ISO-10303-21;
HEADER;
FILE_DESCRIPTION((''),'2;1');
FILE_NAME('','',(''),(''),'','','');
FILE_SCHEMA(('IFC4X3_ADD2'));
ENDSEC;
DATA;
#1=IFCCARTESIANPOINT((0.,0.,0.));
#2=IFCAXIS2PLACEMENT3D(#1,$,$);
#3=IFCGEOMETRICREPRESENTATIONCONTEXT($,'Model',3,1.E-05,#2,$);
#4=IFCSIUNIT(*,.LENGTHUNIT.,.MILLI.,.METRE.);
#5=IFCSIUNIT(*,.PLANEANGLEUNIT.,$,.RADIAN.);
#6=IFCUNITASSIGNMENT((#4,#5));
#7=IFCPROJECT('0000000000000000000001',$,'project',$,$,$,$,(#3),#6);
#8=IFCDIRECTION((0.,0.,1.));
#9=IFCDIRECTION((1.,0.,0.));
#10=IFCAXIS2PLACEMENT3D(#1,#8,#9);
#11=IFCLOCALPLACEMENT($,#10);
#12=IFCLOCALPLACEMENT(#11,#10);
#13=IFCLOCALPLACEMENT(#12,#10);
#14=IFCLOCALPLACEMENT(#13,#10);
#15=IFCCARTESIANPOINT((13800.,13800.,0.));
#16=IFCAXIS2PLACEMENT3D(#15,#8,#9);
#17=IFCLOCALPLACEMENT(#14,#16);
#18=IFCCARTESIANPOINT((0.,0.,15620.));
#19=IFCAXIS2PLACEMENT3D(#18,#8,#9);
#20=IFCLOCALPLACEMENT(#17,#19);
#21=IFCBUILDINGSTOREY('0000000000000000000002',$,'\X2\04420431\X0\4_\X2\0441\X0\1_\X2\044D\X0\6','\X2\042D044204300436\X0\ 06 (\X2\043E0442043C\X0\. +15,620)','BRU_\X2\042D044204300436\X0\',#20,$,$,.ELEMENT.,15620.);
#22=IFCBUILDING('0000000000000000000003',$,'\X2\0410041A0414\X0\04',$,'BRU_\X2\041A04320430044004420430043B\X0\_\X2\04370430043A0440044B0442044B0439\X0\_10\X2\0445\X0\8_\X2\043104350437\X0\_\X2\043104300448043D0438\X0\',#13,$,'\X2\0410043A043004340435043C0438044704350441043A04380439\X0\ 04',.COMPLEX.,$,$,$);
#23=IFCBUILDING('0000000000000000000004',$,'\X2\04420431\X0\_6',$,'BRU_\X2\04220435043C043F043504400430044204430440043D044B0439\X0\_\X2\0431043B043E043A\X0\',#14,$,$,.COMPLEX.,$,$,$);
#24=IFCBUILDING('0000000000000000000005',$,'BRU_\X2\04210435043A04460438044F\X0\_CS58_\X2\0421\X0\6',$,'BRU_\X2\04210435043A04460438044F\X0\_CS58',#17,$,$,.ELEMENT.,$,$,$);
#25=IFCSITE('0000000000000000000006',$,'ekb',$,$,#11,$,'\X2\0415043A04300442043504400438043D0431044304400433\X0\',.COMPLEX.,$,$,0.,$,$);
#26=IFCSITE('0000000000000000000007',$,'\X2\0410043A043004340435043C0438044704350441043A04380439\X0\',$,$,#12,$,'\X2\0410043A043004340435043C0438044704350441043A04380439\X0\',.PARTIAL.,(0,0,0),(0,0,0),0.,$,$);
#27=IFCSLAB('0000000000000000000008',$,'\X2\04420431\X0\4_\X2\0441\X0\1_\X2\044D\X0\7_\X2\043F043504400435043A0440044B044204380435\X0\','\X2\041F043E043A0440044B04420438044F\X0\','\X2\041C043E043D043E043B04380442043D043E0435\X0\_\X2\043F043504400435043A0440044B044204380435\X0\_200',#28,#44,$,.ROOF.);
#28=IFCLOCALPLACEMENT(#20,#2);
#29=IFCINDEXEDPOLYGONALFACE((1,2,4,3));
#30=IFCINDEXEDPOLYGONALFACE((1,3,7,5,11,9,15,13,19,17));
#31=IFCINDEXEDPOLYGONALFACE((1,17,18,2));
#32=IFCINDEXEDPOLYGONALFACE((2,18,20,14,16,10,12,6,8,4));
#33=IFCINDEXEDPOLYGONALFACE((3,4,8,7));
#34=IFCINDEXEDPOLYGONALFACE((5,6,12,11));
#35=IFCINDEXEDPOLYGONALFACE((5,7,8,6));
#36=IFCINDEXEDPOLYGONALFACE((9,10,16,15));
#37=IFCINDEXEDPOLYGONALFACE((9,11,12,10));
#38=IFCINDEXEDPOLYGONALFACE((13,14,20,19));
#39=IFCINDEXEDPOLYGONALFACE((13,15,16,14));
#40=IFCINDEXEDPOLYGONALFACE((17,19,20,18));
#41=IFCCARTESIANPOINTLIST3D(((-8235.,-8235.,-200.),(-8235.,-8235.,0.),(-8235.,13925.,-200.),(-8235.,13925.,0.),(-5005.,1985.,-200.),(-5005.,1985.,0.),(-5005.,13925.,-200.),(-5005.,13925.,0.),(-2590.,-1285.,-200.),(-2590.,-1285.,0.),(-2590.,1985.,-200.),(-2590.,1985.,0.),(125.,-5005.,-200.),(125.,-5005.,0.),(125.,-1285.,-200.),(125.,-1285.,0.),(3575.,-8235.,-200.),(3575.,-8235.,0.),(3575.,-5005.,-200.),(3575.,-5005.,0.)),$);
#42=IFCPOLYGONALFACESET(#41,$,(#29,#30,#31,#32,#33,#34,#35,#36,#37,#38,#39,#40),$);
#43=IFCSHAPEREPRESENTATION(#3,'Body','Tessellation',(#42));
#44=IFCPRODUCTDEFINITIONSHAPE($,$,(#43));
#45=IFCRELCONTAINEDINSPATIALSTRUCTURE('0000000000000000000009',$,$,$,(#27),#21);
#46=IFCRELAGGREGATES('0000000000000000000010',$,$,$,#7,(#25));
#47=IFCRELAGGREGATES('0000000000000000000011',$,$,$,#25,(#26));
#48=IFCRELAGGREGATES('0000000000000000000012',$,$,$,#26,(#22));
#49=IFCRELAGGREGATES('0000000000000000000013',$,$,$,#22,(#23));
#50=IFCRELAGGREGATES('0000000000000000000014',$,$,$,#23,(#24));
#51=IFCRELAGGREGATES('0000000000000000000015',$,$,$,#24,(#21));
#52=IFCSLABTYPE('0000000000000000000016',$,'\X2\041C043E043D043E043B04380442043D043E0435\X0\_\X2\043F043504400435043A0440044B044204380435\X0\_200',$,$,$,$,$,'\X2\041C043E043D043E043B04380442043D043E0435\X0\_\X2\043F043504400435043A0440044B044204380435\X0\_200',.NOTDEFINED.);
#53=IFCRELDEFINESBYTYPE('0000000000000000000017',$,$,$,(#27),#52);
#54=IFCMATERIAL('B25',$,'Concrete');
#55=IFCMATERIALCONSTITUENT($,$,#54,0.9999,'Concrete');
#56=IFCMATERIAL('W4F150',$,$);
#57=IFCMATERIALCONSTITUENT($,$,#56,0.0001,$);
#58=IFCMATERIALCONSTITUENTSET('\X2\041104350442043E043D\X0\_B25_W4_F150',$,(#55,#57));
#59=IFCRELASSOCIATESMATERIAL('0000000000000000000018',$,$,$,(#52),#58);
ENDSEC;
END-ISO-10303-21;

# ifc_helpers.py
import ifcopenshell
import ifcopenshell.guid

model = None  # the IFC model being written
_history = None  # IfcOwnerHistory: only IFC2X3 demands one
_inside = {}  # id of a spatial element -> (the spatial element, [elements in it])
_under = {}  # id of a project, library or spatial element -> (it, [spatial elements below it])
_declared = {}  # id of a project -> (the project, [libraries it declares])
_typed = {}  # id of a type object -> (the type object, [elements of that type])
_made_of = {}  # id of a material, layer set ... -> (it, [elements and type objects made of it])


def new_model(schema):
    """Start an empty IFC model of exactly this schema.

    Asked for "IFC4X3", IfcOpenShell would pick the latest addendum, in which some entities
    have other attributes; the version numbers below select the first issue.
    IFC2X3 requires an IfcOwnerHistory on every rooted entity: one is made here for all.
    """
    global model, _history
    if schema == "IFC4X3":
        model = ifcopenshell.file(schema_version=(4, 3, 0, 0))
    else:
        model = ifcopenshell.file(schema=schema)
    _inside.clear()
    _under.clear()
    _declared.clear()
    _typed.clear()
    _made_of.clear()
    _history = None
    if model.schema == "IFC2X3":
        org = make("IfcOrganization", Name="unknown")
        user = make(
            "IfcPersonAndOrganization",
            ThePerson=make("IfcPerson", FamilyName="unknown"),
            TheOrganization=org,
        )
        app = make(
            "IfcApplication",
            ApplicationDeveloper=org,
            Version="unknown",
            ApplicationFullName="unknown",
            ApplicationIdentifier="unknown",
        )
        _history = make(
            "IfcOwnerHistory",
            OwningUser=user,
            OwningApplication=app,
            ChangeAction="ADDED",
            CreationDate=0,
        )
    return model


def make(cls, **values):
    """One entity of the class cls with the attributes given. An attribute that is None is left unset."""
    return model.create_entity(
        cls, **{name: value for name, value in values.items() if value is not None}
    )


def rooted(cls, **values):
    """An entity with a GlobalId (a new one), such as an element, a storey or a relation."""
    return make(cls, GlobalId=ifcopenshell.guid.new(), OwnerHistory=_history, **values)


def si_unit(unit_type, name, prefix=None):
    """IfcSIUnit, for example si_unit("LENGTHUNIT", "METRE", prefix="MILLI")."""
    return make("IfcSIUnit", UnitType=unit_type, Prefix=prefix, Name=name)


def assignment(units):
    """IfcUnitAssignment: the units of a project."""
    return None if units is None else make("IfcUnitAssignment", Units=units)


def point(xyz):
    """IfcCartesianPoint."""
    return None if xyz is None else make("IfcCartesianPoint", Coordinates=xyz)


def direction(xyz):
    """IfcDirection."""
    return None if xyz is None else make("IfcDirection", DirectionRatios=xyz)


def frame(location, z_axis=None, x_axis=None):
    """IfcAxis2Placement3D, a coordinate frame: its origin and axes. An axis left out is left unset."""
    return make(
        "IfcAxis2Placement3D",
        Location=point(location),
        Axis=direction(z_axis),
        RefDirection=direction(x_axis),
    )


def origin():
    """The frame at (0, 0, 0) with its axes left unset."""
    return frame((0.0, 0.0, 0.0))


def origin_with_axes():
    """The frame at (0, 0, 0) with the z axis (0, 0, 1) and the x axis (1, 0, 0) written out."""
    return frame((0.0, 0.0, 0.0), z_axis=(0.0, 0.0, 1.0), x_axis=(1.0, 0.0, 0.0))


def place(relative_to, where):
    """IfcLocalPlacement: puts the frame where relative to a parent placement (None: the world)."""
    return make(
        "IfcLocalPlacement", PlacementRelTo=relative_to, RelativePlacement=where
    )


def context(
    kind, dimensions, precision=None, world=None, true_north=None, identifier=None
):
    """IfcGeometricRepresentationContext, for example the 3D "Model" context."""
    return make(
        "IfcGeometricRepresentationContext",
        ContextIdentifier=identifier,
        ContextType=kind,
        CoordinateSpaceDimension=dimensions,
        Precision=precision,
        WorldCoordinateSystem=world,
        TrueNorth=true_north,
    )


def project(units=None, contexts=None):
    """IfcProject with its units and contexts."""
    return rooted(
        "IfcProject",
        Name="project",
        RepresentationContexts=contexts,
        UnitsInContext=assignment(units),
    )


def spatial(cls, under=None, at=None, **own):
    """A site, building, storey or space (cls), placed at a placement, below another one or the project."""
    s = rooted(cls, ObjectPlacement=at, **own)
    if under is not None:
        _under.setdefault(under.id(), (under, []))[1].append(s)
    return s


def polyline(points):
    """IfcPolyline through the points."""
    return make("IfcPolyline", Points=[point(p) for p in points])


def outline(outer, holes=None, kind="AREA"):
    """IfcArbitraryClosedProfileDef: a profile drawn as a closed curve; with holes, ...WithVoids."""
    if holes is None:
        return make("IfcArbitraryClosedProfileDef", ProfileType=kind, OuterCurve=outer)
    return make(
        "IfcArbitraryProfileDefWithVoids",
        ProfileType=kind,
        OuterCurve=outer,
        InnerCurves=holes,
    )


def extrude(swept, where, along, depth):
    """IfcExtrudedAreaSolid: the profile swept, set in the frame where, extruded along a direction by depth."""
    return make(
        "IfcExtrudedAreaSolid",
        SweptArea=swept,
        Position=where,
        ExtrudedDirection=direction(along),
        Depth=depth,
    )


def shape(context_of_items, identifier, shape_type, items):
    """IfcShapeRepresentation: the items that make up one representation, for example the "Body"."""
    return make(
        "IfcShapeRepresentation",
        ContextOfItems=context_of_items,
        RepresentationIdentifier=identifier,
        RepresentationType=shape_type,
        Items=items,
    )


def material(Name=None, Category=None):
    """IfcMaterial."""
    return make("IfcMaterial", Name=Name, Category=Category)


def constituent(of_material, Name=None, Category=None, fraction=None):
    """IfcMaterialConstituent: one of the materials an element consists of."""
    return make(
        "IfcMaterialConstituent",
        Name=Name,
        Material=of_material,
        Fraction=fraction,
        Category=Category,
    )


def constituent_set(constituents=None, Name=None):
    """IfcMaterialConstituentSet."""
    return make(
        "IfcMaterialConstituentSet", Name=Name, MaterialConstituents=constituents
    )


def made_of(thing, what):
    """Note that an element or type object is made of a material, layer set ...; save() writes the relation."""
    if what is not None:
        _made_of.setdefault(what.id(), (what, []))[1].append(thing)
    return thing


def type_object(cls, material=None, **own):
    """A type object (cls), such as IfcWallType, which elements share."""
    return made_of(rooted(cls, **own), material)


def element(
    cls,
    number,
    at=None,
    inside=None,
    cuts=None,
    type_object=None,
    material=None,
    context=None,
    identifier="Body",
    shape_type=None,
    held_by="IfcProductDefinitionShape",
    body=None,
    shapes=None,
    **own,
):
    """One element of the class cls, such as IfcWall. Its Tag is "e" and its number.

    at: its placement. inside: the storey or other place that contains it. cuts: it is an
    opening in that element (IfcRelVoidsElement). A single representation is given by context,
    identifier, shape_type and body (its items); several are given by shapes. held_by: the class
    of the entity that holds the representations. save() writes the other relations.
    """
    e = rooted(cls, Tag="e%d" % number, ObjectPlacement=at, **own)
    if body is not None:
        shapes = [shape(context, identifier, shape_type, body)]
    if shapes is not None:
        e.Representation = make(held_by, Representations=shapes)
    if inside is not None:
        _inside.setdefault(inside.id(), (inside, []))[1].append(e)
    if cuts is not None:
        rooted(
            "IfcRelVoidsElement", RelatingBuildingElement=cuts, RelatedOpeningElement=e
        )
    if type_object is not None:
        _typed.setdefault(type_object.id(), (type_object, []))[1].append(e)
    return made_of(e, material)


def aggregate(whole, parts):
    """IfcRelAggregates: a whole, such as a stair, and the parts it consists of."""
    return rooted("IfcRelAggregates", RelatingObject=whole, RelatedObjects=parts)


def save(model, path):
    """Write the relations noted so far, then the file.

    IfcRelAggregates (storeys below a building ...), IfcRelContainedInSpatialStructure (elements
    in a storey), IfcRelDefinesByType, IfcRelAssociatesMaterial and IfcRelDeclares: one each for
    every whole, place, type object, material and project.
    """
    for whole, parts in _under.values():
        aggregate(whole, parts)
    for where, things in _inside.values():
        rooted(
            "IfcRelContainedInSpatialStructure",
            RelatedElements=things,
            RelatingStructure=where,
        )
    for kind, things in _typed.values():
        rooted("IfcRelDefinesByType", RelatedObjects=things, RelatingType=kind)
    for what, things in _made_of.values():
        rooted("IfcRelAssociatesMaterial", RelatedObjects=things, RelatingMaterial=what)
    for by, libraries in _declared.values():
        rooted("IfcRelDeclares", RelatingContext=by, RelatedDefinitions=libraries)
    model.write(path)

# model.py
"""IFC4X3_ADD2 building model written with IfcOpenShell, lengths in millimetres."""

from ifc_helpers import new_model, si_unit, frame, origin, origin_with_axes, place, context, project, spatial, polyline, outline, extrude, material, constituent, constituent_set, type_object, element, save


model = new_model("IFC4X3_ADD2")

# Units and contexts
model_context = context("Model", 3, precision=1e-05, world=origin())
ifc_project = project(units=[si_unit("LENGTHUNIT", "METRE", prefix="MILLI"), si_unit("PLANEANGLEUNIT", "RADIAN")], contexts=[model_context])

# Sites, buildings, storey
site_1_placement = place(None, origin_with_axes())
site_1 = spatial("IfcSite", under=ifc_project, at=site_1_placement, Name="ekb", LongName="Екатеринбург", CompositionType="COMPLEX", RefElevation=0.0)
site_2_placement = place(site_1_placement, origin_with_axes())
site_2 = spatial("IfcSite", under=site_1, at=site_2_placement, Name="Академический", LongName="Академический", CompositionType="PARTIAL", RefLatitude=(0, 0, 0), RefLongitude=(0, 0, 0), RefElevation=0.0)
building_1_placement = place(site_2_placement, origin_with_axes())
building_1 = spatial("IfcBuilding", under=site_2, at=building_1_placement, Name="АКД04", ObjectType="BRU_Квартал_закрытый_10х8_без_башни", LongName="Академический 04", CompositionType="COMPLEX")
building_2_placement = place(building_1_placement, origin_with_axes())
building_2 = spatial("IfcBuilding", under=building_1, at=building_2_placement, Name="тб_6", ObjectType="BRU_Температурный_блок", CompositionType="COMPLEX")
building_3_placement = place(building_2_placement, frame((13800.0, 13800.0, 0.0), z_axis=(0.0, 0.0, 1.0), x_axis=(1.0, 0.0, 0.0)))
building_3 = spatial("IfcBuilding", under=building_2, at=building_3_placement, Name="BRU_Секция_CS58_С6", ObjectType="BRU_Секция_CS58", CompositionType="ELEMENT")
storey_placement = place(building_3_placement, frame((0.0, 0.0, 15620.0), z_axis=(0.0, 0.0, 1.0), x_axis=(1.0, 0.0, 0.0)))
storey = spatial("IfcBuildingStorey", under=building_3, at=storey_placement, Name="тб4_с1_э6", Description="Этаж 06 (отм. +15,620)", ObjectType="BRU_Этаж", CompositionType="ELEMENT", Elevation=15620.0)

# Slab
ifc_material_1 = material(Name="B25", Category="Concrete")
ifc_constituent_1 = constituent(ifc_material_1, Category="Concrete", fraction=0.9999)
ifc_material_2 = material(Name="W4F150")
ifc_constituent_2 = constituent(ifc_material_2, fraction=0.0001)
ifc_constituent_set = constituent_set(constituents=[ifc_constituent_1, ifc_constituent_2], Name="Бетон_B25_W4_F150")
slab_type = type_object("IfcSlabType", Name="Монолитное_перекрытие_200", ElementType="Монолитное_перекрытие_200", PredefinedType="NOTDEFINED", material=ifc_constituent_set)
slab_placement = place(storey_placement, frame((0.0, 0.0, -200.0), z_axis=(0.0, 0.0, 1.0), x_axis=(1.0, 0.0, 0.0)))
element("IfcSlab", 1, at=slab_placement, inside=storey, type_object=slab_type, Name="тб4_с1_э7_перекрытие", Description="Покрытия", ObjectType="Монолитное_перекрытие_200", PredefinedType="ROOF", context=model_context, shape_type="SweptSolid", body=[
    extrude(outline(polyline([(-8235.0, -8235.0), (-8235.0, 13925.0), (-5005.0, 13925.0), (-5005.0, 1985.0), (-2590.0, 1985.0), (-2590.0, -1285.0), (125.0, -1285.0), (125.0, -5005.0), (3575.0, -5005.0), (3575.0, -8235.0), (-8235.0, -8235.0)])), origin_with_axes(), (0.0, 0.0, 1.0), 200.0),
])

save(model, "model.ifc")
